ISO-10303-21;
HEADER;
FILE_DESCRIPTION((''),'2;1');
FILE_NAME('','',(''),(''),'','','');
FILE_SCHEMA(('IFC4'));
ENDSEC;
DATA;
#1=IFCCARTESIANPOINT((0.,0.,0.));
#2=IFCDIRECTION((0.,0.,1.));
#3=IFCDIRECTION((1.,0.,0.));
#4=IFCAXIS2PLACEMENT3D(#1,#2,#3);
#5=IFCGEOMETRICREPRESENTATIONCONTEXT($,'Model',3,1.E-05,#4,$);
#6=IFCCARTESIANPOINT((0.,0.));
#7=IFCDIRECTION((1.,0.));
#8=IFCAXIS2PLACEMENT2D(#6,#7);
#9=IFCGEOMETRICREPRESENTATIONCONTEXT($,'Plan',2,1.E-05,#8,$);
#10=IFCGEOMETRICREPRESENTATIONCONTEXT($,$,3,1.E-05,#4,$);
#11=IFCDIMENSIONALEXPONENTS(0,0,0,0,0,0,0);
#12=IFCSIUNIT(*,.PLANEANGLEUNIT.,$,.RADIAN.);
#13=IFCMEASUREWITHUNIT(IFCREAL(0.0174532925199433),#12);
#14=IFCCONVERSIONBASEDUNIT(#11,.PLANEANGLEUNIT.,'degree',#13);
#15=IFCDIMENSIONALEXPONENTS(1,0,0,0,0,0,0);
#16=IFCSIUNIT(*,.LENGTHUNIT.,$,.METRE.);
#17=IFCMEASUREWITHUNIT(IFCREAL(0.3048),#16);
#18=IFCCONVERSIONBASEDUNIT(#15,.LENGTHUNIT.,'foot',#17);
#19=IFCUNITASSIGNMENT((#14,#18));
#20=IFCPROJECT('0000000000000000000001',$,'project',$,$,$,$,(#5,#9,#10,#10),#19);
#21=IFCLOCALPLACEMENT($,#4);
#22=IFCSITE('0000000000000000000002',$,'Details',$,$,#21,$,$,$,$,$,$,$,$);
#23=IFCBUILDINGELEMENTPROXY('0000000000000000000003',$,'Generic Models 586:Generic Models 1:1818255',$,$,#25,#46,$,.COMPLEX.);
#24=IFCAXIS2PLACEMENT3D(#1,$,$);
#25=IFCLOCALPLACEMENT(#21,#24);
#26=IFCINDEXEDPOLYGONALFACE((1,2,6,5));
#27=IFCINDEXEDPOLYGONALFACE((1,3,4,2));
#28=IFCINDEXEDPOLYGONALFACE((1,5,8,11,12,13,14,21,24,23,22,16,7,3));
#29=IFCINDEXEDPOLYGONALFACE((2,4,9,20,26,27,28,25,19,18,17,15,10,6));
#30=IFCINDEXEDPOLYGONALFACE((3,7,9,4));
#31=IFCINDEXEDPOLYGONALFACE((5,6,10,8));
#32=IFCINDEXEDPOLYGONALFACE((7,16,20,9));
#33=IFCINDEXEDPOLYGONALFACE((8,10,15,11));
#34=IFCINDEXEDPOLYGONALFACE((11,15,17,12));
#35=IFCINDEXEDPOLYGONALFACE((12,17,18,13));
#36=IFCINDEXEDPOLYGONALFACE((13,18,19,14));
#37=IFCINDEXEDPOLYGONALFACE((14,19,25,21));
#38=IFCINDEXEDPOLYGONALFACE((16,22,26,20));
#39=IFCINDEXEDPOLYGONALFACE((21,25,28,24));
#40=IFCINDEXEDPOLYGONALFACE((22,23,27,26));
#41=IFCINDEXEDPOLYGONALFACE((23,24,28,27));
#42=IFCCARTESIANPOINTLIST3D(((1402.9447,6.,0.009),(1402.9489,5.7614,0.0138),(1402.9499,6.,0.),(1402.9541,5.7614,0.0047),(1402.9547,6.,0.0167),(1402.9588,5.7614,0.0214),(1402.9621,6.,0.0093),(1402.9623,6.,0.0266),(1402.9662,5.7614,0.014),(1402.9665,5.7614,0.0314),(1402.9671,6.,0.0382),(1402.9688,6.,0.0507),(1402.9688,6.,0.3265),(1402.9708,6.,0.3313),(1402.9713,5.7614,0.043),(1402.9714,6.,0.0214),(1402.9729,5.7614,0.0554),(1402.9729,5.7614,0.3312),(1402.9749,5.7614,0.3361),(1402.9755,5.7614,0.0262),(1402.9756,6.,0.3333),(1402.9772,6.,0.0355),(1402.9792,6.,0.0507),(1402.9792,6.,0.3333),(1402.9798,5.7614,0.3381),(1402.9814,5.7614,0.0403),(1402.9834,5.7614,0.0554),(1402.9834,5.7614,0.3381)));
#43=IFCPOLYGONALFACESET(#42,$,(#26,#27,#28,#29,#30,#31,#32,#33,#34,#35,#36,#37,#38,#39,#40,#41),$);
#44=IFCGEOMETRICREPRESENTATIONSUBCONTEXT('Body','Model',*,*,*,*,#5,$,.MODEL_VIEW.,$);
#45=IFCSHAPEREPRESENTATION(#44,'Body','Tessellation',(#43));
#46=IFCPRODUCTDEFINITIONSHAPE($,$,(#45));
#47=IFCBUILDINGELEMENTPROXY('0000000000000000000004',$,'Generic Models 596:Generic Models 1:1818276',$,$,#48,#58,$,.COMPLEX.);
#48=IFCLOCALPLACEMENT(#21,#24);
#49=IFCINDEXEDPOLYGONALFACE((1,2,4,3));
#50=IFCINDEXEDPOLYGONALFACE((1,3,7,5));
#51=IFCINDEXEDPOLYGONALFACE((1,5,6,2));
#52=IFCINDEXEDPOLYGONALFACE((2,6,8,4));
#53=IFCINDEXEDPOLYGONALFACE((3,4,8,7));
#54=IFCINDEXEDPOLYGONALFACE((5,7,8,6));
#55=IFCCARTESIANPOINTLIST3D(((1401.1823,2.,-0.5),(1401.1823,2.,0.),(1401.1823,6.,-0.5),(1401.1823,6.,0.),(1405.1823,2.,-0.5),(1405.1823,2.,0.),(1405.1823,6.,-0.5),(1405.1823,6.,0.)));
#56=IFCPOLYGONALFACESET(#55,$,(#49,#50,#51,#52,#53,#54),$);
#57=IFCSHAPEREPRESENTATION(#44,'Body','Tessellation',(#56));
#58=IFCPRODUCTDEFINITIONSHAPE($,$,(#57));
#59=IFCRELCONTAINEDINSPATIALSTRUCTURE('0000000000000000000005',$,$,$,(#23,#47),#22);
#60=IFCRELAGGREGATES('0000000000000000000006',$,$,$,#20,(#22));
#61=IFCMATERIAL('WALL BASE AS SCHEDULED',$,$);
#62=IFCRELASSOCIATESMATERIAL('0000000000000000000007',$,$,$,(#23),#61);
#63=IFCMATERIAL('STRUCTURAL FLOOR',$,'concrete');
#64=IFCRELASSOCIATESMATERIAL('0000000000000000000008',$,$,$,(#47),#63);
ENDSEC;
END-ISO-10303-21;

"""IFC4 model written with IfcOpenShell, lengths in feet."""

from ifc_helpers import new_model, entity, si_unit, converted_unit, frame, origin_with_axes, origin_2d_with_axis, place, context, subcontext, project, spatial, polyline, outline, extrude, material, element, save


model = new_model("IFC4")

# Units and contexts
model_context = context("Model", 3, precision=1e-05, world=origin_with_axes())
plan_context = context("Plan", 2, precision=1e-05, world=origin_2d_with_axis())
context_of_model = context(None, 3, precision=1e-05, world=origin_with_axes())
body_context = subcontext(model_context, "Body", "Model", "MODEL_VIEW")
ifc_project = project(units=[converted_unit("PLANEANGLEUNIT", "degree", entity("IfcReal", 0.0174532925199433), si_unit("PLANEANGLEUNIT", "RADIAN"), dimensions=[0, 0, 0, 0, 0, 0, 0]), converted_unit("LENGTHUNIT", "foot", entity("IfcReal", 0.3048), si_unit("LENGTHUNIT", "METRE"), dimensions=[1, 0, 0, 0, 0, 0, 0])], contexts=[model_context, plan_context, context_of_model, context_of_model])

# Site
site_placement = place(None, origin_with_axes())
site = spatial("IfcSite", under=ifc_project, at=site_placement, Name="Details")

# Building element proxies
ifc_material_1 = material(Name="WALL BASE AS SCHEDULED")
ifc_material_2 = material(Name="STRUCTURAL FLOOR", Category="concrete")
proxy_1_placement = place(site_placement, frame((1402.9447, 6.0, 0.0), z_axis=(0.0, -1.0, 0.0), x_axis=(0.0, 0.0, 1.0)))
element("IfcBuildingElementProxy", 1, at=proxy_1_placement, inside=site, material=ifc_material_1, Name="Generic Models 586:Generic Models 1:1818255", PredefinedType="COMPLEX", context=body_context, shape_type="SweptSolid", body=[
    extrude(outline(polyline([(0.0748, 0.0), (0.0624, -0.0017), (-0.2134, -0.0039), (-0.2182, -0.0059), (-0.2202, -0.0108), (-0.2202, -0.0144), (0.0625, -0.0122), (0.0776, -0.01), (0.0917, -0.0041), (0.1037, 0.0053), (0.1129, 0.0175), (0.1039, 0.0226), (0.0963, 0.0126), (0.0864, 0.0049), (0.0748, 0.0)])), frame((0.113, -0.0218, 0.0), z_axis=(0.0, 0.0, -1.0), x_axis=(-0.99997, -0.007803, 0.0)), (-0.019684, -0.017536, -0.999652), 0.2387),
])
proxy_2_placement = place(site_placement, frame((1401.1823, 6.0, -0.5), z_axis=(0.0, -1.0, 0.0), x_axis=(0.0, 0.0, 1.0)))
element("IfcBuildingElementProxy", 2, at=proxy_2_placement, inside=site, material=ifc_material_2, Name="Generic Models 596:Generic Models 1:1818276", PredefinedType="COMPLEX", context=body_context, shape_type="SweptSolid", body=[
    extrude(outline(polyline([(-0.25, -2.0), (0.25, -2.0), (0.25, 2.0), (-0.25, 2.0), (-0.25, -2.0)])), frame((0.25, -2.0, 0.0), z_axis=(0.0, 0.0, -1.0), x_axis=(-1.0, 0.0, 0.0)), (0.0, 0.0, -1.0), 4.0),
])

save(model, "model.ifc")
